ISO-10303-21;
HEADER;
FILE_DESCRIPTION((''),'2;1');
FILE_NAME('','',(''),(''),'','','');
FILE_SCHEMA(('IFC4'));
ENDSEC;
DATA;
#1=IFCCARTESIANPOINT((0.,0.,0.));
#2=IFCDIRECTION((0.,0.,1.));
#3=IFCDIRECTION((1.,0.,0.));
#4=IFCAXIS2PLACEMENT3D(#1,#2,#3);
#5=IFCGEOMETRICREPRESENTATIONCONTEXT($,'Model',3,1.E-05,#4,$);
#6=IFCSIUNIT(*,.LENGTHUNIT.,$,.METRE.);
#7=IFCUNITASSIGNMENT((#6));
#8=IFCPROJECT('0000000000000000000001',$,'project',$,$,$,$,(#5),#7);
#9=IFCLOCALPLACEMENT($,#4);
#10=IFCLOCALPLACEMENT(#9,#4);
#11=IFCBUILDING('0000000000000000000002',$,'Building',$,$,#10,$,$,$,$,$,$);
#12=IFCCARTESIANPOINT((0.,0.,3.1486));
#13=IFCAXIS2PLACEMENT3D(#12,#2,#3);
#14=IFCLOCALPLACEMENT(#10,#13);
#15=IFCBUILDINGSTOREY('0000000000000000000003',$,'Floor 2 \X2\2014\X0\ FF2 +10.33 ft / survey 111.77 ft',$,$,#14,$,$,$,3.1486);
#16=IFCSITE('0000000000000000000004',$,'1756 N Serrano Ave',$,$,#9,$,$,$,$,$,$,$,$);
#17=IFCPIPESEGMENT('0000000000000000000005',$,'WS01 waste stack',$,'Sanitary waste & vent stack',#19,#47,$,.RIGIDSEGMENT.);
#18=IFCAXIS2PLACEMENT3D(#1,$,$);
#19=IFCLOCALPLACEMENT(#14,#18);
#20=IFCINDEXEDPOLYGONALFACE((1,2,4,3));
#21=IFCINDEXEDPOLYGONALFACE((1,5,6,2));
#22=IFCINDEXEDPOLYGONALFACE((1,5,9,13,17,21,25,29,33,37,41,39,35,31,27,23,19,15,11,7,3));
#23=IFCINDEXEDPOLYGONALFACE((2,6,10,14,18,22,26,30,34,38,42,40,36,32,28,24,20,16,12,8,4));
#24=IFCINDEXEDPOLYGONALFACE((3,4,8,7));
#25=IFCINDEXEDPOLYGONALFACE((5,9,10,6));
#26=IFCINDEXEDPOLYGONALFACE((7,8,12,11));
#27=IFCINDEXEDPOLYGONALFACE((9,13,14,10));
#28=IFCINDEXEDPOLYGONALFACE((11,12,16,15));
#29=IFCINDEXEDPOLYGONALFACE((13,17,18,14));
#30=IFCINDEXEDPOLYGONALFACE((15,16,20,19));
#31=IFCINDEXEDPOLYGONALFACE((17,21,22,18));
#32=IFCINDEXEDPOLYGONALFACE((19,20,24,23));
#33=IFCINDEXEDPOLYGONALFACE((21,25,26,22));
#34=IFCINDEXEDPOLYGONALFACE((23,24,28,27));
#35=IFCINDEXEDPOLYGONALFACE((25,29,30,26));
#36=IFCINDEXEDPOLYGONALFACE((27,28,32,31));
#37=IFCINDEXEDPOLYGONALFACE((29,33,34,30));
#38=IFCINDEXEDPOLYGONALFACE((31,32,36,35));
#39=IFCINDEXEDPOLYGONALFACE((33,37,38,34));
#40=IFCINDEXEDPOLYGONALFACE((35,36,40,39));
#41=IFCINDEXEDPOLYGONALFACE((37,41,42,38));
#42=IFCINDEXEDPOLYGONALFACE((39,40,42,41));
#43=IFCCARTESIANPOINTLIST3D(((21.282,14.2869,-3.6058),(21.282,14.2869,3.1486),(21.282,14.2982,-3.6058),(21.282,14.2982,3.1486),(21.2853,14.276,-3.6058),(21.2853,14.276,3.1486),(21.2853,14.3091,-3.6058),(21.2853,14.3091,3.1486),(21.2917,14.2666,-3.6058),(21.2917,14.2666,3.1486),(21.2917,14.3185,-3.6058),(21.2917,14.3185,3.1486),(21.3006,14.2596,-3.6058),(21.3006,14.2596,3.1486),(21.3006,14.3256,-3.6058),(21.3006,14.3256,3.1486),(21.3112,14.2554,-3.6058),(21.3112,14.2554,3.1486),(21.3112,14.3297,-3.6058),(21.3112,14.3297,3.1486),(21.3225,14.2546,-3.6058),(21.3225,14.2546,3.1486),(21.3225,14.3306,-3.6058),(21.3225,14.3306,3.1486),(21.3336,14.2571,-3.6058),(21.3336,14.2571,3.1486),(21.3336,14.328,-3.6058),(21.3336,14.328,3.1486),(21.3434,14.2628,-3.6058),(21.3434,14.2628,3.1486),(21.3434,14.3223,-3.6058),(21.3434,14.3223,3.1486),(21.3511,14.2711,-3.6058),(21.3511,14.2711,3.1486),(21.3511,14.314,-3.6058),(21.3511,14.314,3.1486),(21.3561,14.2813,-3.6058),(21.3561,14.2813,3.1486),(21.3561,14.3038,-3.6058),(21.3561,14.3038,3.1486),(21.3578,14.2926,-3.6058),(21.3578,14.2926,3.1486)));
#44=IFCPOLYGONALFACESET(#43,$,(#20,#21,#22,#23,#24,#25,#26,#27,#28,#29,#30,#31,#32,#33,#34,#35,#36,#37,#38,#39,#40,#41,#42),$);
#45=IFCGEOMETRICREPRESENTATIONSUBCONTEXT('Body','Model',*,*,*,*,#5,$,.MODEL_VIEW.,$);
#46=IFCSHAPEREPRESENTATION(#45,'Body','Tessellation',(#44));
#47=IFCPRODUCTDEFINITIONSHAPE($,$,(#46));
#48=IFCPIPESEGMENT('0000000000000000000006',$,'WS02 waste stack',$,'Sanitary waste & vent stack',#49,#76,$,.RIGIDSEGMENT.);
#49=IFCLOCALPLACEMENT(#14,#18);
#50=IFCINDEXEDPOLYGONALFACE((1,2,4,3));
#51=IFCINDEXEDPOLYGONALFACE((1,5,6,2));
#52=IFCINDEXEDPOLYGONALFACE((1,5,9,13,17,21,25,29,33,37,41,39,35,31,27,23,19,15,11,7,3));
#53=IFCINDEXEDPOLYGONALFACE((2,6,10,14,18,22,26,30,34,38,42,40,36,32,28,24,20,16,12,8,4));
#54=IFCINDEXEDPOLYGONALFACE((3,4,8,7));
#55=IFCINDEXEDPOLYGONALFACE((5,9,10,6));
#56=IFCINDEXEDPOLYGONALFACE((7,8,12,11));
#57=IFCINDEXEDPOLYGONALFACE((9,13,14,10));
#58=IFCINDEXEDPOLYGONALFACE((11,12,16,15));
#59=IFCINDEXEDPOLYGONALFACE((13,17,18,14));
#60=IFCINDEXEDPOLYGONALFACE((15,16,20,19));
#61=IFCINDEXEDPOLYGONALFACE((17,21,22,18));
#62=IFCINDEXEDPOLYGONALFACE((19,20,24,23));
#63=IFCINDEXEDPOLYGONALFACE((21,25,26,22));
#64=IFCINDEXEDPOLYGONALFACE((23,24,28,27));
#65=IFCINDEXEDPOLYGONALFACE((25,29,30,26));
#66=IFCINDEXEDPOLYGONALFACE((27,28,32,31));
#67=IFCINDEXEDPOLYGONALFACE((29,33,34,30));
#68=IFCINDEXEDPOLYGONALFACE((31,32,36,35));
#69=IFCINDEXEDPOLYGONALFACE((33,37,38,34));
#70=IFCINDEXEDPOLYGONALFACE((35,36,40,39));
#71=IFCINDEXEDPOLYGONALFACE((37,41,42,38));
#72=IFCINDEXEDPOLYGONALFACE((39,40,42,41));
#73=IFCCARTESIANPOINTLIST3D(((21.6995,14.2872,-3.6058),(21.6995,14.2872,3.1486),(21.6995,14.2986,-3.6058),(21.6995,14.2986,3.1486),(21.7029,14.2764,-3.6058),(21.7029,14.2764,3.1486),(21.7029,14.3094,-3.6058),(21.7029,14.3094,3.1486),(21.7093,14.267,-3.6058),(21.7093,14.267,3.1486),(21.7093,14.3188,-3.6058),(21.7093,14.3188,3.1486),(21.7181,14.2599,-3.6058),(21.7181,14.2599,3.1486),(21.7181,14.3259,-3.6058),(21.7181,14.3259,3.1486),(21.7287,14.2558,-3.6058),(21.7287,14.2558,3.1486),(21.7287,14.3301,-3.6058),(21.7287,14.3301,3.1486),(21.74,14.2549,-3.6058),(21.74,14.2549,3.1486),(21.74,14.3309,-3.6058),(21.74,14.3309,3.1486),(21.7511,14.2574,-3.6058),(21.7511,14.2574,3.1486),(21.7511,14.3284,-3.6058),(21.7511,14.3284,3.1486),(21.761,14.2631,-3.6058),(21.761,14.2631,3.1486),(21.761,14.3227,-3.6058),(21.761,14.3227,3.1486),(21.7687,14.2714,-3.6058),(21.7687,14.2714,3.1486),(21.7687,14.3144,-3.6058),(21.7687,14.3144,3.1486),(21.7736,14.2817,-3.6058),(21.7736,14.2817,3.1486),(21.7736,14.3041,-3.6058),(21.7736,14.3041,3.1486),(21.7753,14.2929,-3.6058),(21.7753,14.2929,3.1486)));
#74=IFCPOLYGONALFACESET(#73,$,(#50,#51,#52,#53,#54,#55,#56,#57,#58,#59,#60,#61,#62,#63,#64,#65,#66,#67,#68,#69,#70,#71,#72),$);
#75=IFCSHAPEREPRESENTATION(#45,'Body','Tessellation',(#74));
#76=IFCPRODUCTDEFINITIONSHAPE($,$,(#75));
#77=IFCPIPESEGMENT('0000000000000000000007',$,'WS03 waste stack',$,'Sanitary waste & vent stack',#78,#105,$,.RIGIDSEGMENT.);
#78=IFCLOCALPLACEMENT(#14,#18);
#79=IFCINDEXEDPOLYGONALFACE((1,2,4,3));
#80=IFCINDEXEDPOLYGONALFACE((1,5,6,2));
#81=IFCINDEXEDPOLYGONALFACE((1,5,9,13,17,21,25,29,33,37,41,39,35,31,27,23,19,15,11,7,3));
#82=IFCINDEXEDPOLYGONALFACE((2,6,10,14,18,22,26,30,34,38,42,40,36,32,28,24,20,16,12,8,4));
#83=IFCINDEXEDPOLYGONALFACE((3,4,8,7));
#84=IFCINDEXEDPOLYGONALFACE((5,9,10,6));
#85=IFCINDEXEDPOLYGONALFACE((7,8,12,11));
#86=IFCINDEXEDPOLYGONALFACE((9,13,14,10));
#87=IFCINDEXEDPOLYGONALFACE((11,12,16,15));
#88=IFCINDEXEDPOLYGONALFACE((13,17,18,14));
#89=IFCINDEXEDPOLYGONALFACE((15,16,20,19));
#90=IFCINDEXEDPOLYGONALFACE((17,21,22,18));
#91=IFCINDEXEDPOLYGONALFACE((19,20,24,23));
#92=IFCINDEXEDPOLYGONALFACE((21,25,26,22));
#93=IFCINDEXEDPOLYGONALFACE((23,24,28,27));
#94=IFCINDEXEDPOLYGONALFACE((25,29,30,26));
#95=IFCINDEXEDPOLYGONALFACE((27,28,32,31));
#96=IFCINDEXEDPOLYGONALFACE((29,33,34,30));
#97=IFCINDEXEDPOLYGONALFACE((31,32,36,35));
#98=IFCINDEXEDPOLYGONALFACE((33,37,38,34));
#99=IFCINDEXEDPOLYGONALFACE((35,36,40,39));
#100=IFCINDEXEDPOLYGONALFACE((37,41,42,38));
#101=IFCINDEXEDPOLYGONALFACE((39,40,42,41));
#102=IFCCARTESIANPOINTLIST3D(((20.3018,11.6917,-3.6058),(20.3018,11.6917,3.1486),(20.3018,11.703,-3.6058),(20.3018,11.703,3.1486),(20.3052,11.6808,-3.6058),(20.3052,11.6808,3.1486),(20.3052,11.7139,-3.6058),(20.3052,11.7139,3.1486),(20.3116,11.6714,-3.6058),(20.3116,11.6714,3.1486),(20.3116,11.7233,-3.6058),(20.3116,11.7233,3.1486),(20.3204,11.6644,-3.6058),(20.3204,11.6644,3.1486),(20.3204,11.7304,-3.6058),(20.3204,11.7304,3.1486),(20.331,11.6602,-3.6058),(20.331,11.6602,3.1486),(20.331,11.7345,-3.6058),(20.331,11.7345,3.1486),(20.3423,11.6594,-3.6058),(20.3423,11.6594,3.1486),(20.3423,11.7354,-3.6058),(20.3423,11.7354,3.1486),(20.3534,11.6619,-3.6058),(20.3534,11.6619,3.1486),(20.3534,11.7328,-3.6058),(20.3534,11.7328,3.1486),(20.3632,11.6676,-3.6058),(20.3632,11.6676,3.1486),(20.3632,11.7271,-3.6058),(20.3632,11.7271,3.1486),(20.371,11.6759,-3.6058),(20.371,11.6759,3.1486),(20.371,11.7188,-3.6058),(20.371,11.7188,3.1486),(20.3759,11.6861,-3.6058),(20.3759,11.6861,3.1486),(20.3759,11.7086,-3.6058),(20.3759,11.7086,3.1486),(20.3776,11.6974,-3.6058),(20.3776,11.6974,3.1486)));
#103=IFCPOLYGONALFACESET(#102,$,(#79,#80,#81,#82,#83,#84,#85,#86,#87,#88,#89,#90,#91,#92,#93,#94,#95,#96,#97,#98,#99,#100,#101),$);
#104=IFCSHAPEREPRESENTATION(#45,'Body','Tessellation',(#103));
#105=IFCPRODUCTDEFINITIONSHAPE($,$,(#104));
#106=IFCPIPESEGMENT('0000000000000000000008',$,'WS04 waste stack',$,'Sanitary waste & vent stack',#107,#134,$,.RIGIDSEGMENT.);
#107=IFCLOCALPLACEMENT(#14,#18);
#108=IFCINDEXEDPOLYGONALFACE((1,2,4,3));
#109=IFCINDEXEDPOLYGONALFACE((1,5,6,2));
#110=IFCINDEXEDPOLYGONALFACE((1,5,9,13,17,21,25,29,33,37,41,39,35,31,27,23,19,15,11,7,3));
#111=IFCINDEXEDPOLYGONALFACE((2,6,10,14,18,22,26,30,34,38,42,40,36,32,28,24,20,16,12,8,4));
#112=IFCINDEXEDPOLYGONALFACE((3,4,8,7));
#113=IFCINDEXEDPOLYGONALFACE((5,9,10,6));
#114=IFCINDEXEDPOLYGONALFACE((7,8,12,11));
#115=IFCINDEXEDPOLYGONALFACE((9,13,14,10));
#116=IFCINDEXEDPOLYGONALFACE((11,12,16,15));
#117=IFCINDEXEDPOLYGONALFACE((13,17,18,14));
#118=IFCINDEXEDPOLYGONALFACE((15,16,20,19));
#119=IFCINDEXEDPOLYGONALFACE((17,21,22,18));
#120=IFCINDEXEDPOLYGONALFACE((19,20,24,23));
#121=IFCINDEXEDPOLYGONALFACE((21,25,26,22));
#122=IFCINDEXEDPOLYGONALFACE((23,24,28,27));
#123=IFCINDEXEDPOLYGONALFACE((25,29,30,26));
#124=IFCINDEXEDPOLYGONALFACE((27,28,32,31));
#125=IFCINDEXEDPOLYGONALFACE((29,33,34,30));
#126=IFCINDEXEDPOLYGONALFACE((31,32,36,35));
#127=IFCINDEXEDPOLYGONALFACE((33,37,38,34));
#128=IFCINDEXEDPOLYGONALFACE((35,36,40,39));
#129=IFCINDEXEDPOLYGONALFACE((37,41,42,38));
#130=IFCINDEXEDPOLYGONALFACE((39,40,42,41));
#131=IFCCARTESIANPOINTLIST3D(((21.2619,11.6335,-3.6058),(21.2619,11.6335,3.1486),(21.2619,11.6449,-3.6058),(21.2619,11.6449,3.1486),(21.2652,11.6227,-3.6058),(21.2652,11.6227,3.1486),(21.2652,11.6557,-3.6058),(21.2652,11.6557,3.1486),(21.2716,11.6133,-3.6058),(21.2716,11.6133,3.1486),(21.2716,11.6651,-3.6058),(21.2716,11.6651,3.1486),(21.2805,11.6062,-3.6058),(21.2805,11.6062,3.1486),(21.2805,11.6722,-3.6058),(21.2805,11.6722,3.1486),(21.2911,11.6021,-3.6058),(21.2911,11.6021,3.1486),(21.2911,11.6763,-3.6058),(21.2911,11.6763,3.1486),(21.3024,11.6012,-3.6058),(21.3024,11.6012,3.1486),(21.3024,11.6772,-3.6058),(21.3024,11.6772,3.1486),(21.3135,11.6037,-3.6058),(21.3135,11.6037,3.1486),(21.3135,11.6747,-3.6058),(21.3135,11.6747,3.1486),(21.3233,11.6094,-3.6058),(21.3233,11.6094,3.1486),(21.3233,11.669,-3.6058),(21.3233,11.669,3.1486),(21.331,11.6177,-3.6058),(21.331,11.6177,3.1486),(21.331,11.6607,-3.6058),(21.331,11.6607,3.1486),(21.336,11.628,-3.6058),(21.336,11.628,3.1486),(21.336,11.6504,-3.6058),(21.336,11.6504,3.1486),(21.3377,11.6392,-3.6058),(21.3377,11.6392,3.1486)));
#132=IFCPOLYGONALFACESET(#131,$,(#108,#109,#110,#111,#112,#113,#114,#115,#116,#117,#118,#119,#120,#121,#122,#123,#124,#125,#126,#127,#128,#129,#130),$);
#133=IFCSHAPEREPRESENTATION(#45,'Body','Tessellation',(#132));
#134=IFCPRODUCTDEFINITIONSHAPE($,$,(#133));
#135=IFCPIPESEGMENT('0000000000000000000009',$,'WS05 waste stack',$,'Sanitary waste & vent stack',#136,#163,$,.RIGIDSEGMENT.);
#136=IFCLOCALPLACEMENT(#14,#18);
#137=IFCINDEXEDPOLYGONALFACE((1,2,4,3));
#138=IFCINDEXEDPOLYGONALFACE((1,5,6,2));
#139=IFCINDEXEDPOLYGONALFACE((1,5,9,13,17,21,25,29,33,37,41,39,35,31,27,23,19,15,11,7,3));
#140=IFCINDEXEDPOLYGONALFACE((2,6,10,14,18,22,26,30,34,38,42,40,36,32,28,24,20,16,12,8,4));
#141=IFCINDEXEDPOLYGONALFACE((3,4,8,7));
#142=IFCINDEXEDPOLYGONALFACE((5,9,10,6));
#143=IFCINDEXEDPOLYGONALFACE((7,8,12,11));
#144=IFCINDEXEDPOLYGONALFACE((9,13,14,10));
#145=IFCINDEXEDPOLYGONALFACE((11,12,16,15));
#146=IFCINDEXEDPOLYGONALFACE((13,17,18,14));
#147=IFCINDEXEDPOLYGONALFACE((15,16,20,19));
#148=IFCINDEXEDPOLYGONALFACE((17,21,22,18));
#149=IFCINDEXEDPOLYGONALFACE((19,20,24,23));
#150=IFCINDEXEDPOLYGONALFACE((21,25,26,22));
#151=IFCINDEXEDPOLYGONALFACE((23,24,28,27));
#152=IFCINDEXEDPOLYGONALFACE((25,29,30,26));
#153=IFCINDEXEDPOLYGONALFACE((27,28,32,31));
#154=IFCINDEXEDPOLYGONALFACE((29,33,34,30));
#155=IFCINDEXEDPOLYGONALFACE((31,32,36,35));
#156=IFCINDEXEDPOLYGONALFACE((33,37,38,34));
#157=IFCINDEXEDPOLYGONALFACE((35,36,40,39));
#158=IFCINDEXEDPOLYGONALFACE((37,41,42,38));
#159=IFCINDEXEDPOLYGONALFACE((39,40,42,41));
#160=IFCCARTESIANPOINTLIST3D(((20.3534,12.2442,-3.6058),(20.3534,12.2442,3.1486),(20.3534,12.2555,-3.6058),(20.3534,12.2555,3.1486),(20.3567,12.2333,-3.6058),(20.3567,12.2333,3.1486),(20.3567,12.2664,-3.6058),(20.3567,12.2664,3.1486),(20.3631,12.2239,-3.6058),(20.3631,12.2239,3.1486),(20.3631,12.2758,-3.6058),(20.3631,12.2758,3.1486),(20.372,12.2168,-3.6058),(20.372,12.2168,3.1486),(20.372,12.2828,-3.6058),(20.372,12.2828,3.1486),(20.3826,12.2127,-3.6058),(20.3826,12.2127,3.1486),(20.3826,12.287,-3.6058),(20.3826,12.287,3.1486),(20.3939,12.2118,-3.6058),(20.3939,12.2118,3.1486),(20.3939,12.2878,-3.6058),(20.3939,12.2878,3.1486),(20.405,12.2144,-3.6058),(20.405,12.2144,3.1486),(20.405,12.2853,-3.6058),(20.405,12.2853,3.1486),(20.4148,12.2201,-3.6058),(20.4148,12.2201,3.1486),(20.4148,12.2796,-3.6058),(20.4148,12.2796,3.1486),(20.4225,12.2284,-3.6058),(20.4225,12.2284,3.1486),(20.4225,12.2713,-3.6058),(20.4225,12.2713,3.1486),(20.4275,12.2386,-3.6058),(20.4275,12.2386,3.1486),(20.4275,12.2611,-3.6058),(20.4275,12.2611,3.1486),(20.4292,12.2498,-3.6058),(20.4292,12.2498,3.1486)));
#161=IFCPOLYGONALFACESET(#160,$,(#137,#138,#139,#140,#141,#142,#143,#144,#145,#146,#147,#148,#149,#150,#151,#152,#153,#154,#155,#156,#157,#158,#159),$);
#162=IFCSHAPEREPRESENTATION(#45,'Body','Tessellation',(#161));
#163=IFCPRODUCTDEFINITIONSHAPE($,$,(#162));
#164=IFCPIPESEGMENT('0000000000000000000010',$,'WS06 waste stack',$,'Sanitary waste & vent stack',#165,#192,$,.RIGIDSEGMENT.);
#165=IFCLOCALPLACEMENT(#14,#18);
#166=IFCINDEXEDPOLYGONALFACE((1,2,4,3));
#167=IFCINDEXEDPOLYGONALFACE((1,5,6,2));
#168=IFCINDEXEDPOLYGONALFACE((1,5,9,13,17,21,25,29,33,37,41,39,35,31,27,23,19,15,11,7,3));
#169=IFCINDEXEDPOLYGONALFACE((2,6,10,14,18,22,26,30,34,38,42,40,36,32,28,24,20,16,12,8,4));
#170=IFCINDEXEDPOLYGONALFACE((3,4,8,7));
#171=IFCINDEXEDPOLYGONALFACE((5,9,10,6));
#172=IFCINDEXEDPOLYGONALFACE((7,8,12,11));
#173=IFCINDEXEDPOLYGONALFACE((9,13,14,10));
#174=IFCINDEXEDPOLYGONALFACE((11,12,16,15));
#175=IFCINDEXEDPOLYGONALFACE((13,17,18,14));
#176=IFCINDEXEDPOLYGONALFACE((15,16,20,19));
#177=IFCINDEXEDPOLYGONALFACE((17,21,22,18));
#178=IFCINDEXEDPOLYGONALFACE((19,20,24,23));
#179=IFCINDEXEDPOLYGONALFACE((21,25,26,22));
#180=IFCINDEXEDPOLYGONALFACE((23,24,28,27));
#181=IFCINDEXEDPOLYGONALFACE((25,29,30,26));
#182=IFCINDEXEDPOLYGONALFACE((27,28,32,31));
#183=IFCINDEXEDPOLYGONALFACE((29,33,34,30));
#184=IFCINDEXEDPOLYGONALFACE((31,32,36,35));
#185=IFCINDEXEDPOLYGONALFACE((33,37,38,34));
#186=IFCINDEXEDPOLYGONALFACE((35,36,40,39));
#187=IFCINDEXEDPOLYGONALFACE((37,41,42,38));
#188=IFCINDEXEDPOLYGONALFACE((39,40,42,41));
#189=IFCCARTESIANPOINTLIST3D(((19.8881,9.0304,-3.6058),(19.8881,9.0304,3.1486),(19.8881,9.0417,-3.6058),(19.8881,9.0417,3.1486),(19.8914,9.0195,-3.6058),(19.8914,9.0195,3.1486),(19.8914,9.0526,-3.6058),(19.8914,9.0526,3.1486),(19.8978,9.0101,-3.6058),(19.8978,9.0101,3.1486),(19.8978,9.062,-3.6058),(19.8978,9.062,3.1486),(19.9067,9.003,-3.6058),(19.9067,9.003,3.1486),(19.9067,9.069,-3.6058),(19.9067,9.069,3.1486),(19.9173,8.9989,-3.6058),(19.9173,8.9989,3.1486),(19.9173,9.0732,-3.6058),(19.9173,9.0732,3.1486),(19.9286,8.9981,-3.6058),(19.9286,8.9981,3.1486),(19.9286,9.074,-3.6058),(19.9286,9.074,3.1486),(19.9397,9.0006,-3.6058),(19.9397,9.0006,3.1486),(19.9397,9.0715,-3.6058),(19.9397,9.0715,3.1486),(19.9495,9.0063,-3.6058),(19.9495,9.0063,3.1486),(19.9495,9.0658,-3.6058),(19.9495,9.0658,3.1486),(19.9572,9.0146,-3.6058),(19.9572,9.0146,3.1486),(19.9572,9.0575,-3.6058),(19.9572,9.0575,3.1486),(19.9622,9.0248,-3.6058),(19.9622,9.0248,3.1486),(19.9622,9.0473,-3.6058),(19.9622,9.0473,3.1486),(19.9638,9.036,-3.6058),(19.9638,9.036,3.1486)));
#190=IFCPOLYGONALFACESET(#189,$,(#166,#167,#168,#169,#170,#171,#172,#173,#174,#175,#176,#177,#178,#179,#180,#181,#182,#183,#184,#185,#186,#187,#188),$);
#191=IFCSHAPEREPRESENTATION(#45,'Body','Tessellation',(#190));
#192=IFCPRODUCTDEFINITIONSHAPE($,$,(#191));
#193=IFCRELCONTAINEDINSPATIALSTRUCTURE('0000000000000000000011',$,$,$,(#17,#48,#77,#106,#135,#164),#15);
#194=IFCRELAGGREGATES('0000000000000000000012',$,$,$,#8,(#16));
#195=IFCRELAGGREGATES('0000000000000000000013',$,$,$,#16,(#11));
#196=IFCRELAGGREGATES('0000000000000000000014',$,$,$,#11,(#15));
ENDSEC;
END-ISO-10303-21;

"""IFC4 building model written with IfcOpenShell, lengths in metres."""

from ifc_helpers import new_model, entity, si_unit, frame, origin_with_axes, place, context, subcontext, project, spatial, element, save


model = new_model("IFC4")

# Units and contexts
model_context = context("Model", 3, precision=1e-05, world=origin_with_axes())
body_context = subcontext(model_context, "Body", "Model", "MODEL_VIEW")
ifc_project = project(units=[si_unit("LENGTHUNIT", "METRE")], contexts=[model_context])

# Site, building, storey
site_placement = place(None, origin_with_axes())
site = spatial("IfcSite", under=ifc_project, at=site_placement, Name="1756 N Serrano Ave")
building_placement = place(site_placement, origin_with_axes())
building = spatial("IfcBuilding", under=site, at=building_placement, Name="Building")
storey_placement = place(building_placement, frame((0.0, 0.0, 3.1486), z_axis=(0.0, 0.0, 1.0), x_axis=(1.0, 0.0, 0.0)))
storey = spatial("IfcBuildingStorey", under=building, at=storey_placement, Name="Floor 2 — FF2 +10.33 ft / survey 111.77 ft", Elevation=3.1486)

# Pipe segments
pipe_segment_1_placement = place(storey_placement, frame((0.0, 0.0, -3.1486), z_axis=(0.0, 0.0, 1.0), x_axis=(1.0, 0.0, 0.0)))
element("IfcPipeSegment", 1, at=pipe_segment_1_placement, inside=storey, Name="WS01 waste stack", ObjectType="Sanitary waste & vent stack", PredefinedType="RIGIDSEGMENT", context=body_context, shape_type="AdvancedSweptSolid", body=[
    entity("IfcSweptDiskSolid", entity("IfcPolyline", [entity("IfcCartesianPoint", [21.3197, 14.2926, -0.4572]), entity("IfcCartesianPoint", [21.3197, 14.2926, 6.2972])]), 0.0381),
])
pipe_segment_2_placement = place(storey_placement, frame((0.0, 0.0, -3.1486), z_axis=(0.0, 0.0, 1.0), x_axis=(1.0, 0.0, 0.0)))
element("IfcPipeSegment", 2, at=pipe_segment_2_placement, inside=storey, Name="WS02 waste stack", ObjectType="Sanitary waste & vent stack", PredefinedType="RIGIDSEGMENT", context=body_context, shape_type="AdvancedSweptSolid", body=[
    entity("IfcSweptDiskSolid", entity("IfcPolyline", [entity("IfcCartesianPoint", [21.7372, 14.2929, -0.4572]), entity("IfcCartesianPoint", [21.7372, 14.2929, 6.2972])]), 0.0381),
])
pipe_segment_3_placement = place(storey_placement, frame((0.0, 0.0, -3.1486), z_axis=(0.0, 0.0, 1.0), x_axis=(1.0, 0.0, 0.0)))
element("IfcPipeSegment", 3, at=pipe_segment_3_placement, inside=storey, Name="WS03 waste stack", ObjectType="Sanitary waste & vent stack", PredefinedType="RIGIDSEGMENT", context=body_context, shape_type="AdvancedSweptSolid", body=[
    entity("IfcSweptDiskSolid", entity("IfcPolyline", [entity("IfcCartesianPoint", [20.3395, 11.6974, -0.4572]), entity("IfcCartesianPoint", [20.3395, 11.6974, 6.2972])]), 0.0381),
])
pipe_segment_4_placement = place(storey_placement, frame((0.0, 0.0, -3.1486), z_axis=(0.0, 0.0, 1.0), x_axis=(1.0, 0.0, 0.0)))
element("IfcPipeSegment", 4, at=pipe_segment_4_placement, inside=storey, Name="WS04 waste stack", ObjectType="Sanitary waste & vent stack", PredefinedType="RIGIDSEGMENT", context=body_context, shape_type="AdvancedSweptSolid", body=[
    entity("IfcSweptDiskSolid", entity("IfcPolyline", [entity("IfcCartesianPoint", [21.2996, 11.6392, -0.4572]), entity("IfcCartesianPoint", [21.2996, 11.6392, 6.2972])]), 0.0381),
])
pipe_segment_5_placement = place(storey_placement, frame((0.0, 0.0, -3.1486), z_axis=(0.0, 0.0, 1.0), x_axis=(1.0, 0.0, 0.0)))
element("IfcPipeSegment", 5, at=pipe_segment_5_placement, inside=storey, Name="WS05 waste stack", ObjectType="Sanitary waste & vent stack", PredefinedType="RIGIDSEGMENT", context=body_context, shape_type="AdvancedSweptSolid", body=[
    entity("IfcSweptDiskSolid", entity("IfcPolyline", [entity("IfcCartesianPoint", [20.3911, 12.2498, -0.4572]), entity("IfcCartesianPoint", [20.3911, 12.2498, 6.2972])]), 0.0381),
])
pipe_segment_6_placement = place(storey_placement, frame((0.0, 0.0, -3.1486), z_axis=(0.0, 0.0, 1.0), x_axis=(1.0, 0.0, 0.0)))
element("IfcPipeSegment", 6, at=pipe_segment_6_placement, inside=storey, Name="WS06 waste stack", ObjectType="Sanitary waste & vent stack", PredefinedType="RIGIDSEGMENT", context=body_context, shape_type="AdvancedSweptSolid", body=[
    entity("IfcSweptDiskSolid", entity("IfcPolyline", [entity("IfcCartesianPoint", [19.9257, 9.036, -0.4572]), entity("IfcCartesianPoint", [19.9257, 9.036, 6.2972])]), 0.0381),
])

save(model, "model.ifc")
